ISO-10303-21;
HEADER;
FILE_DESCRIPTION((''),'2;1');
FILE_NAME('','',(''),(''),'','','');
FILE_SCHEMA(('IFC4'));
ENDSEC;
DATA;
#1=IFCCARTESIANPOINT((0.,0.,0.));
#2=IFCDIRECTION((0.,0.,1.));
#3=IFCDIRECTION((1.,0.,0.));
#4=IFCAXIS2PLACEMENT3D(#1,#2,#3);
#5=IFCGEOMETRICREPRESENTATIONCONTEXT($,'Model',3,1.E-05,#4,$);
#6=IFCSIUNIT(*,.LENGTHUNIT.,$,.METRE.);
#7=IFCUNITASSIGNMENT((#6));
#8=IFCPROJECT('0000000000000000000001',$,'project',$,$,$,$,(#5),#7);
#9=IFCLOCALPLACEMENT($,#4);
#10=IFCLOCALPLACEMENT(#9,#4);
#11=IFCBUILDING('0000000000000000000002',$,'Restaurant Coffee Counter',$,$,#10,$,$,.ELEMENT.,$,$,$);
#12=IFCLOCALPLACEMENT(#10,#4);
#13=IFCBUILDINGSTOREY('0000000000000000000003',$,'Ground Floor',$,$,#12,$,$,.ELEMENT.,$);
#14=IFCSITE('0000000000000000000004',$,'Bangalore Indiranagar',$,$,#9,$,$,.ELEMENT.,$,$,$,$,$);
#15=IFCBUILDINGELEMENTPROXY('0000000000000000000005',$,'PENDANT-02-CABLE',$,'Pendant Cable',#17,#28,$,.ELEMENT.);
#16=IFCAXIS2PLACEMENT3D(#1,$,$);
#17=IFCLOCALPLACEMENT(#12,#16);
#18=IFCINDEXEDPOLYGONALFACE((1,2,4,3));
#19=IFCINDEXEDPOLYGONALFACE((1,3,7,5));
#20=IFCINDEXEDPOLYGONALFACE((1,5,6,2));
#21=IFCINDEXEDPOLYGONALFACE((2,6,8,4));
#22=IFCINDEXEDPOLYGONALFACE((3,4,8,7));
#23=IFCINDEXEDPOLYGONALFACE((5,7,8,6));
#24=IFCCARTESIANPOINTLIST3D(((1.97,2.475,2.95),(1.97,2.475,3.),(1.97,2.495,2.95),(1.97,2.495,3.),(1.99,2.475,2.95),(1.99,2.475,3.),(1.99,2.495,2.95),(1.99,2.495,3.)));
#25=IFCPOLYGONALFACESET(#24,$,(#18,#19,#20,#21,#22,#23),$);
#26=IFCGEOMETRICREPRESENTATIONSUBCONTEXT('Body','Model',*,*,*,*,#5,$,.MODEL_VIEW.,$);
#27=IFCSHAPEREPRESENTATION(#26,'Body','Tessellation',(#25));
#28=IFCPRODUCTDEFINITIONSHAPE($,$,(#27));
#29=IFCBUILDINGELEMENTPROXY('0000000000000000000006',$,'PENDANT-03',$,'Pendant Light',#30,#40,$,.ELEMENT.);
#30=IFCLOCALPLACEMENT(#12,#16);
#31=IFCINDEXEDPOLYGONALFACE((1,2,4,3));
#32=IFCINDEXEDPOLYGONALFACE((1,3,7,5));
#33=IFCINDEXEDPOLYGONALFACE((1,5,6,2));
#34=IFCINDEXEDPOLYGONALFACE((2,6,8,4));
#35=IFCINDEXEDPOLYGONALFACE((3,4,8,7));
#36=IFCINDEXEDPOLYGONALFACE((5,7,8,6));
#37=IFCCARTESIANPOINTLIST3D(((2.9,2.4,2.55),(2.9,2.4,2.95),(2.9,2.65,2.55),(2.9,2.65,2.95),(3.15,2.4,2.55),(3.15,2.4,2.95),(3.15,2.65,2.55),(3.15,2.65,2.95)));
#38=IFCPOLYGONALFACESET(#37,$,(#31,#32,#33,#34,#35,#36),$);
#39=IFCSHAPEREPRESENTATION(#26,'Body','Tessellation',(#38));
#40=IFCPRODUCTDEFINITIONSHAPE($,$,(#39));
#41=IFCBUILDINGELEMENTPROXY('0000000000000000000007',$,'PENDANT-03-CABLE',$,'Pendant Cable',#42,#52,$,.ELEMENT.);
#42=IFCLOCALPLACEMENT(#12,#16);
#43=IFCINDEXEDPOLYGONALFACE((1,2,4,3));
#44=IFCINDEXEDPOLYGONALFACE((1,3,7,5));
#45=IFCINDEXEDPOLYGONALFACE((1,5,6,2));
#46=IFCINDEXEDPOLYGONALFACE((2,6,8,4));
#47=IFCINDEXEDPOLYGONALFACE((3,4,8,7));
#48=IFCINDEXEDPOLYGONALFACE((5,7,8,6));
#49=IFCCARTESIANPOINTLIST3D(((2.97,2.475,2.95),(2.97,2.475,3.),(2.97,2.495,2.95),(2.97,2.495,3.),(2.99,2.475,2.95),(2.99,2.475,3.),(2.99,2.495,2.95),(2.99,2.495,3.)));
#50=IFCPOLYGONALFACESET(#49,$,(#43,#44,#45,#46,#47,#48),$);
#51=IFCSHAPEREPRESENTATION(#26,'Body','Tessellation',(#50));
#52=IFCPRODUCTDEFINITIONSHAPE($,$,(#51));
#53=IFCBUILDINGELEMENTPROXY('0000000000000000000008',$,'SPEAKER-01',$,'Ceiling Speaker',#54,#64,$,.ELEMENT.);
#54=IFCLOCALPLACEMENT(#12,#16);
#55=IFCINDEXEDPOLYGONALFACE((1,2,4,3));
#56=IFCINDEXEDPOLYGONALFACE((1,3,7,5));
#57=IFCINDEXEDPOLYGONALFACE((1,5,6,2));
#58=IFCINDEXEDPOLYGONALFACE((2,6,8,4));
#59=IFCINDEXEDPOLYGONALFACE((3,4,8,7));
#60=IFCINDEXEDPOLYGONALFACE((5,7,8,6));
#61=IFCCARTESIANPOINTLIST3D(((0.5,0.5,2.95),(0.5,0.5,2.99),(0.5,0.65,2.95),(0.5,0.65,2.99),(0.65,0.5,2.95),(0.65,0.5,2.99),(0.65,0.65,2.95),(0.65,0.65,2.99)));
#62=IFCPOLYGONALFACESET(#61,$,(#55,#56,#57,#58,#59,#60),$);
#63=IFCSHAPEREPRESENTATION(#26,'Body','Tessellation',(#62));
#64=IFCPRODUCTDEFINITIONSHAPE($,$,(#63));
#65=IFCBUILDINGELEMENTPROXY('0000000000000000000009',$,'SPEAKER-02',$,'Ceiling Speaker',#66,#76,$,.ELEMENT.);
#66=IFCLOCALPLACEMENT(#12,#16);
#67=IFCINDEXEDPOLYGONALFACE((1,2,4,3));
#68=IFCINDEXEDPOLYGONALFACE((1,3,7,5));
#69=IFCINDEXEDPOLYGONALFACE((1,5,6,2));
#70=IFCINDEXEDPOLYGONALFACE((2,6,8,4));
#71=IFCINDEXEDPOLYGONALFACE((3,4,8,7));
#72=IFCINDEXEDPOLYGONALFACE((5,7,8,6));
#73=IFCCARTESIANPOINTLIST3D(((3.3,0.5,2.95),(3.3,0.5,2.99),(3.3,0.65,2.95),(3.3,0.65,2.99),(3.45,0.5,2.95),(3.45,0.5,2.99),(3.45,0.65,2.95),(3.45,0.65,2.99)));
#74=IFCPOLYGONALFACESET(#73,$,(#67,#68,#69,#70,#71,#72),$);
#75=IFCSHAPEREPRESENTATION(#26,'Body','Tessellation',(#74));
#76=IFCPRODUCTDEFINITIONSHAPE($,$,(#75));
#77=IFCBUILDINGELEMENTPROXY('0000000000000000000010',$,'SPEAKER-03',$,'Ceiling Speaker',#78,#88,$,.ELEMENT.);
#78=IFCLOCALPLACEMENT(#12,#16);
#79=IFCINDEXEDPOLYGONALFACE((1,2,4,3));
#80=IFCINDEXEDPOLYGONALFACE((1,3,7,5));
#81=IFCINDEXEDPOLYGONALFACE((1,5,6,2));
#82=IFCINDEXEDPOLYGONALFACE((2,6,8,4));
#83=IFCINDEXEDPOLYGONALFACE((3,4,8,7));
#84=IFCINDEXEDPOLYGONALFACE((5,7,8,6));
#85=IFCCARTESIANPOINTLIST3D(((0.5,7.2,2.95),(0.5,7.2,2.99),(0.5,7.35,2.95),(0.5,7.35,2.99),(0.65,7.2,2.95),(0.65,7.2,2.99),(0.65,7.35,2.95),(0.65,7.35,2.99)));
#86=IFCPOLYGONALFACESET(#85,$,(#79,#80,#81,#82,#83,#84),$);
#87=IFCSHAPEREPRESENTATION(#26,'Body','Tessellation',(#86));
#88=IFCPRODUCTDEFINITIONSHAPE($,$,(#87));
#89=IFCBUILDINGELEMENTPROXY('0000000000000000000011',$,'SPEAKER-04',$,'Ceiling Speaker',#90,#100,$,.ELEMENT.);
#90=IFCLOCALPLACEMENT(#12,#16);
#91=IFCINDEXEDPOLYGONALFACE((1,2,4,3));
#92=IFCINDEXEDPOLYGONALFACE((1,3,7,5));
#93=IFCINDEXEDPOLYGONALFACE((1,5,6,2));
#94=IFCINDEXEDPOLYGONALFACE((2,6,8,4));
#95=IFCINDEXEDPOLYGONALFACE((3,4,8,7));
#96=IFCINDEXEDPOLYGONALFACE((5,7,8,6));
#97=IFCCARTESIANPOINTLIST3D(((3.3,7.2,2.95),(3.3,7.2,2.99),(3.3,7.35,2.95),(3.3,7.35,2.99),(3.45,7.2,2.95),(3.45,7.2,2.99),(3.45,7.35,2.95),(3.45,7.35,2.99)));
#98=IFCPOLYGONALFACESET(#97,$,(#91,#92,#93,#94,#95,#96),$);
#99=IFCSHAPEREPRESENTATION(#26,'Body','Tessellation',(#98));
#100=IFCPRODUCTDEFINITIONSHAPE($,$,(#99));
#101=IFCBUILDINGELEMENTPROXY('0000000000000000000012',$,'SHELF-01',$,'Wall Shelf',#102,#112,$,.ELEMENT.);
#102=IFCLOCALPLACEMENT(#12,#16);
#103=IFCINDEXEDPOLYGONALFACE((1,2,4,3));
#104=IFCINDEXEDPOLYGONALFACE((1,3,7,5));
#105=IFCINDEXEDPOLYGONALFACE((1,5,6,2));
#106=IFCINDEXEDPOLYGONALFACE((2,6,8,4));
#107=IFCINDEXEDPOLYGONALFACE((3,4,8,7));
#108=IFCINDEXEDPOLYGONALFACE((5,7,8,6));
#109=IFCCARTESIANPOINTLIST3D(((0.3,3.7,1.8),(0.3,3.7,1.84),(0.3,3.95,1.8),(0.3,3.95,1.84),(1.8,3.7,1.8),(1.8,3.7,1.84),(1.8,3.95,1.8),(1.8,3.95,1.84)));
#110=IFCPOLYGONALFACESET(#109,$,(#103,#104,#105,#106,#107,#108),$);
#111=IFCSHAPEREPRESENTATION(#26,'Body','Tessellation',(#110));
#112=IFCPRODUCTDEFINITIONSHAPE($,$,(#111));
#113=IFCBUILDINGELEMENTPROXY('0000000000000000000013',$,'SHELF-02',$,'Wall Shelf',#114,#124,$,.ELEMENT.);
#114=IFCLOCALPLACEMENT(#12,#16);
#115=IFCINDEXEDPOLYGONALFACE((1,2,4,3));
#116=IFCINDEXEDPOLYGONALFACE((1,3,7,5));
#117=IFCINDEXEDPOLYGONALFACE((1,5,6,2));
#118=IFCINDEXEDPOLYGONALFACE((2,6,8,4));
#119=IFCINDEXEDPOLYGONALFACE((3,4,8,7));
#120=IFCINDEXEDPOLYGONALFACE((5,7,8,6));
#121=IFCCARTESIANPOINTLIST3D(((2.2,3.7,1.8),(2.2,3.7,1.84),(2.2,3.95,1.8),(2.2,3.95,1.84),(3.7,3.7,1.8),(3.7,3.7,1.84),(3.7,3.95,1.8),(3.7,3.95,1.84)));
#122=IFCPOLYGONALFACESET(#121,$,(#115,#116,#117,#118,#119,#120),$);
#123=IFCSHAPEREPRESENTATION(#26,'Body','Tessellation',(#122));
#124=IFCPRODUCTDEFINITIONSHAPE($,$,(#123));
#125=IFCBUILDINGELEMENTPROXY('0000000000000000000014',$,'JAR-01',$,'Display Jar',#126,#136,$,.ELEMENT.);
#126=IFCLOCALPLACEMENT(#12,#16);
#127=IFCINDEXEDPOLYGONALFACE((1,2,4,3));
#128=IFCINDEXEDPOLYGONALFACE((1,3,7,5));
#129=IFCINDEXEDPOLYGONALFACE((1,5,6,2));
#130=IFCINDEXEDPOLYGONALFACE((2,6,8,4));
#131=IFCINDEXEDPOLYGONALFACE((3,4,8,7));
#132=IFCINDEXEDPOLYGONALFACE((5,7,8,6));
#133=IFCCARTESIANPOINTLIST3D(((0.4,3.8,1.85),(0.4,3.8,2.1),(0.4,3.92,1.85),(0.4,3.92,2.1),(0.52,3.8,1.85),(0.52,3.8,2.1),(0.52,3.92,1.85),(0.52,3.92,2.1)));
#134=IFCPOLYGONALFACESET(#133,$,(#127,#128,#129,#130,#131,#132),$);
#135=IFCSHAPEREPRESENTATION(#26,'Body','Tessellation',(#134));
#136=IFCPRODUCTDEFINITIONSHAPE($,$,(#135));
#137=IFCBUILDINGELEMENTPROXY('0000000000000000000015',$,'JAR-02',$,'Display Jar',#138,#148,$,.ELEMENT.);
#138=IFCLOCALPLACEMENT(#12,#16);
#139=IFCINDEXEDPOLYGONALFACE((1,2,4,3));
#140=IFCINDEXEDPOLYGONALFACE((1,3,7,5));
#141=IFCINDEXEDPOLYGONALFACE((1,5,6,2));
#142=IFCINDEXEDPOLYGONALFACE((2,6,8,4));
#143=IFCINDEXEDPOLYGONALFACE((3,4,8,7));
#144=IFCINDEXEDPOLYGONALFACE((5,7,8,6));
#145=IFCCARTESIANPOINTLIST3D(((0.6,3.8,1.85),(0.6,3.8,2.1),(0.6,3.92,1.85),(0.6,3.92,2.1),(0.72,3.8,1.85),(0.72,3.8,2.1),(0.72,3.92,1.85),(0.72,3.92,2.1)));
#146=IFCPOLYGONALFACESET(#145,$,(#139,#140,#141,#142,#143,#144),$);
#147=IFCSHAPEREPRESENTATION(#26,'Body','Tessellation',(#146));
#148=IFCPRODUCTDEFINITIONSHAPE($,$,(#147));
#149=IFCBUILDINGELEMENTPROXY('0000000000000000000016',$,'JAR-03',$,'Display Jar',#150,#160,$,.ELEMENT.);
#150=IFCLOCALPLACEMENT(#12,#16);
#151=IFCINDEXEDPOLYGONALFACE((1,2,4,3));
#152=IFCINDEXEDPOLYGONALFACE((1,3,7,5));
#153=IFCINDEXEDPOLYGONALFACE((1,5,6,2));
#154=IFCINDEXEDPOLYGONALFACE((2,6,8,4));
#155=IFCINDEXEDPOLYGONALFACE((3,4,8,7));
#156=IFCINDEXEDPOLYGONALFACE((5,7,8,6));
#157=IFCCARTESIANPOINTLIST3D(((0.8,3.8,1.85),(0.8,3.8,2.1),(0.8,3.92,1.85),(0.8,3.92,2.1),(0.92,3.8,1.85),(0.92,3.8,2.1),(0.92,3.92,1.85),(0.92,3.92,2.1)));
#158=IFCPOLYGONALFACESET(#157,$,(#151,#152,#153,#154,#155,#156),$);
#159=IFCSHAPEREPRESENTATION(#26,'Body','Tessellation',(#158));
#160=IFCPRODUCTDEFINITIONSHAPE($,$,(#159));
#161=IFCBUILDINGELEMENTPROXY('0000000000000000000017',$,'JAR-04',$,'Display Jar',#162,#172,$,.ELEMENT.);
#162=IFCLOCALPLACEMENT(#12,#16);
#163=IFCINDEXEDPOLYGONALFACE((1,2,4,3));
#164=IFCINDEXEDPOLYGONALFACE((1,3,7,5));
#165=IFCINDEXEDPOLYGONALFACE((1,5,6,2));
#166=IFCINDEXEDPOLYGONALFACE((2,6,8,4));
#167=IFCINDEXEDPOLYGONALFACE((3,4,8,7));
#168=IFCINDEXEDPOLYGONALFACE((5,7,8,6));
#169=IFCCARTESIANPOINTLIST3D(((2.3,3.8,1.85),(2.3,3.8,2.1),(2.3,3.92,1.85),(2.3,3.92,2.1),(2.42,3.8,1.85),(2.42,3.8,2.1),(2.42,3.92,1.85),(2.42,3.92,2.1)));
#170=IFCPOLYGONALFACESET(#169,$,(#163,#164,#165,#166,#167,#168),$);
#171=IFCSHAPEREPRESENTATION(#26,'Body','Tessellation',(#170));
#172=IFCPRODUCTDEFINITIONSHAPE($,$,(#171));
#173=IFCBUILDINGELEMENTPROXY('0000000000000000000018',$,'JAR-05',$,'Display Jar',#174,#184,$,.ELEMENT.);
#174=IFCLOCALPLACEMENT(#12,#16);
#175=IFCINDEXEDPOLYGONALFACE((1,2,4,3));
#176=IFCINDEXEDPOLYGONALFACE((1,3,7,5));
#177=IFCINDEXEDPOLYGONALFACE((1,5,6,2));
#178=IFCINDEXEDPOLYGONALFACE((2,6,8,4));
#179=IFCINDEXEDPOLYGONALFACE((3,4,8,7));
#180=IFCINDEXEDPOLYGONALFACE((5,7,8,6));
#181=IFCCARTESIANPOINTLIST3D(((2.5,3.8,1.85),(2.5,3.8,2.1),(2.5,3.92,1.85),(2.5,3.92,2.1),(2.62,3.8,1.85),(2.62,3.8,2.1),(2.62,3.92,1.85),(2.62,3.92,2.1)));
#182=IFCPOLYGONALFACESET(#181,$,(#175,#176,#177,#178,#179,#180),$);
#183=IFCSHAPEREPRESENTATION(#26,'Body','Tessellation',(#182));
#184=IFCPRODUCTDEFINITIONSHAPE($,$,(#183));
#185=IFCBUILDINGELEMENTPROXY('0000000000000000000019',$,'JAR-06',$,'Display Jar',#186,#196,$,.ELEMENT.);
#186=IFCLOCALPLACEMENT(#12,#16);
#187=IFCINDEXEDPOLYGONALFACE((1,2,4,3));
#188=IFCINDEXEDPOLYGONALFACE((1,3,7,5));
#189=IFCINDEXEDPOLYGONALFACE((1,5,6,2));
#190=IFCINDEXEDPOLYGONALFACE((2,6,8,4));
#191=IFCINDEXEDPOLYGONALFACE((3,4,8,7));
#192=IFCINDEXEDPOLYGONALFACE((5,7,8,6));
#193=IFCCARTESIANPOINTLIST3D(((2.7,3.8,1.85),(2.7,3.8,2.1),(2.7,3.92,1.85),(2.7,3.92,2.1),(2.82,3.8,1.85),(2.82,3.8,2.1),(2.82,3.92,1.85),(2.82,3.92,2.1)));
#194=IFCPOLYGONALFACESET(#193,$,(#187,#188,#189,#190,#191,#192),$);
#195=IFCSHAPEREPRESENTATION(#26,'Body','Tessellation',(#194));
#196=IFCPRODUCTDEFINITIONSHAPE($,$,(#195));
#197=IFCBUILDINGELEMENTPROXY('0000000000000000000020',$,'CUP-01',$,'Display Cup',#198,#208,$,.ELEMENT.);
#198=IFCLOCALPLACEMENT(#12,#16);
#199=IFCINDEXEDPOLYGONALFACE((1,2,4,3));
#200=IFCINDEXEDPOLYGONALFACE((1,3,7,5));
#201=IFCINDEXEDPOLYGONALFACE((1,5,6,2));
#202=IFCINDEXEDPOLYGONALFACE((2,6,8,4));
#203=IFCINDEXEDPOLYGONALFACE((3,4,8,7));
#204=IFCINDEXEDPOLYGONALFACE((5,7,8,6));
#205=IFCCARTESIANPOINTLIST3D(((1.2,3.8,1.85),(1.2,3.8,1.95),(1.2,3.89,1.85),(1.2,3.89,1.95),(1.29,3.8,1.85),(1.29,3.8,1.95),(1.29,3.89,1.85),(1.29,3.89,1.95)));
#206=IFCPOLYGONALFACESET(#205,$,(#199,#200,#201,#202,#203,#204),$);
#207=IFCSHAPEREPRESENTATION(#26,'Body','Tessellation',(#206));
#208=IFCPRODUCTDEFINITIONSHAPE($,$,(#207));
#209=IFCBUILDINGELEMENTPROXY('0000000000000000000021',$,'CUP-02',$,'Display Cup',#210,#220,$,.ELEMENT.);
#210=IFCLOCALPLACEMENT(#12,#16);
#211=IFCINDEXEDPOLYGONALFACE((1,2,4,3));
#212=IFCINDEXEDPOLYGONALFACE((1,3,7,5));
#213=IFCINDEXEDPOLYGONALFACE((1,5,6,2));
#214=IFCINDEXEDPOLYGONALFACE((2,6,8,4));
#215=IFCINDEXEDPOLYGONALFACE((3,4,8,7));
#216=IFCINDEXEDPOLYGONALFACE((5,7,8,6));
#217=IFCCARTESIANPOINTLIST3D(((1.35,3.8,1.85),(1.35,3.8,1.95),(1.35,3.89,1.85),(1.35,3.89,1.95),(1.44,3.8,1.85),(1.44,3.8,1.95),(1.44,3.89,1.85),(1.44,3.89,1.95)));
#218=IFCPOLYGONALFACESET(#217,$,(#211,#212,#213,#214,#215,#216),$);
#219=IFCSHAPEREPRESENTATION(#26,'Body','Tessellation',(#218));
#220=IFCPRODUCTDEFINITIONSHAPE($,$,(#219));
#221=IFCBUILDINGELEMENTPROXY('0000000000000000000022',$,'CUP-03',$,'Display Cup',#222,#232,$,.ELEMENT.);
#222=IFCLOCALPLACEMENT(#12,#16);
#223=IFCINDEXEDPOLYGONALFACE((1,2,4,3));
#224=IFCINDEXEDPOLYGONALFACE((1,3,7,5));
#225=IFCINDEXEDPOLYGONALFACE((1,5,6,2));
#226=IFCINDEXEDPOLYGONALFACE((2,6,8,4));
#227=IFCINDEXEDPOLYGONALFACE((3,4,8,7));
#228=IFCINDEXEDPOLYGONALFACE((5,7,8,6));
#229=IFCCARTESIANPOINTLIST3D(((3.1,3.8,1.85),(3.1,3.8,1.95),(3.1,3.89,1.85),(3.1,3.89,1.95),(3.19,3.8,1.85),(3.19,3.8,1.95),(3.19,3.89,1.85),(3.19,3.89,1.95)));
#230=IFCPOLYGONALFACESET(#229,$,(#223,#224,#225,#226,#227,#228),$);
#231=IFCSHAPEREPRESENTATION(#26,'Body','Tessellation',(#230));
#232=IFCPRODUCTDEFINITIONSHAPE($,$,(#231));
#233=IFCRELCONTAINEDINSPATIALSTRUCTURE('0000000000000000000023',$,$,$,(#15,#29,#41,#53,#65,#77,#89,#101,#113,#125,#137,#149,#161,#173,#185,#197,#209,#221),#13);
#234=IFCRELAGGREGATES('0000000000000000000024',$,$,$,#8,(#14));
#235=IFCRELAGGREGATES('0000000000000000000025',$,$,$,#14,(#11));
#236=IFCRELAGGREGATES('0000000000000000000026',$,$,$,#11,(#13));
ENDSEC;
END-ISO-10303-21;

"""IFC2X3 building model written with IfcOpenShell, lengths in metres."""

from ifc_helpers import new_model, si_unit, frame, frame_2d, origin, origin_with_axes, place, context, subcontext, project, spatial, rectangle, extrude, element, save


model = new_model("IFC2X3")

# Units and contexts
model_context = context("Model", 3, precision=1e-05, world=origin_with_axes())
body_context = subcontext(model_context, "Body", "Model", "MODEL_VIEW")
ifc_project = project(units=[si_unit("LENGTHUNIT", "METRE")], contexts=[model_context])

# Site, building, storey
site_placement = place(None, origin_with_axes())
site = spatial("IfcSite", under=ifc_project, at=site_placement, Name="Bangalore Indiranagar", CompositionType="ELEMENT")
building_placement = place(site_placement, origin_with_axes())
building = spatial("IfcBuilding", under=site, at=building_placement, Name="Restaurant Coffee Counter", CompositionType="ELEMENT")
storey_placement = place(building_placement, origin_with_axes())
storey = spatial("IfcBuildingStorey", under=building, at=storey_placement, Name="Ground Floor", CompositionType="ELEMENT")

# Building element proxies
proxy_1_placement = place(storey_placement, frame((1.97, 2.475, 2.95), z_axis=(0.0, 0.0, 1.0), x_axis=(1.0, 0.0, 0.0)))
element("IfcBuildingElementProxy", 1, at=proxy_1_placement, inside=storey, Name="PENDANT-02-CABLE", ObjectType="Pendant Cable", CompositionType="ELEMENT", context=body_context, shape_type="SweptSolid", body=[
    extrude(rectangle(XDim=0.02, YDim=0.02, at=frame_2d((0.01, 0.01))), origin(), (0.0, 0.0, 1.0), 0.05),
])
proxy_2_placement = place(storey_placement, frame((2.9, 2.4, 2.55), z_axis=(0.0, 0.0, 1.0), x_axis=(1.0, 0.0, 0.0)))
element("IfcBuildingElementProxy", 2, at=proxy_2_placement, inside=storey, Name="PENDANT-03", ObjectType="Pendant Light", CompositionType="ELEMENT", context=body_context, shape_type="SweptSolid", body=[
    extrude(rectangle(XDim=0.25, YDim=0.25, at=frame_2d((0.125, 0.125))), origin(), (0.0, 0.0, 1.0), 0.4),
])
proxy_3_placement = place(storey_placement, frame((2.97, 2.475, 2.95), z_axis=(0.0, 0.0, 1.0), x_axis=(1.0, 0.0, 0.0)))
element("IfcBuildingElementProxy", 3, at=proxy_3_placement, inside=storey, Name="PENDANT-03-CABLE", ObjectType="Pendant Cable", CompositionType="ELEMENT", context=body_context, shape_type="SweptSolid", body=[
    extrude(rectangle(XDim=0.02, YDim=0.02, at=frame_2d((0.01, 0.01))), origin(), (0.0, 0.0, 1.0), 0.05),
])
for number, where, z_axis, x_axis, name in (
    (4, (0.5, 0.5, 2.95), (0.0, 0.0, 1.0), (1.0, 0.0, 0.0), "SPEAKER-01"),
    (5, (3.3, 0.5, 2.95), (0.0, 0.0, 1.0), (1.0, 0.0, 0.0), "SPEAKER-02"),
    (6, (0.5, 7.2, 2.95), (0.0, 0.0, 1.0), (1.0, 0.0, 0.0), "SPEAKER-03"),
    (7, (3.3, 7.2, 2.95), (0.0, 0.0, 1.0), (1.0, 0.0, 0.0), "SPEAKER-04"),
):
    element("IfcBuildingElementProxy", number, at=place(storey_placement, frame(where, z_axis=z_axis, x_axis=x_axis)), inside=storey, Name=name, ObjectType="Ceiling Speaker", CompositionType="ELEMENT", context=body_context, shape_type="SweptSolid", body=[
        extrude(rectangle(XDim=0.15, YDim=0.15, at=frame_2d((0.075, 0.075))), origin(), (0.0, 0.0, 1.0), 0.04),
    ])
for number, where, z_axis, x_axis, name in (
    (8, (0.3, 3.7, 1.8), (0.0, 0.0, 1.0), (1.0, 0.0, 0.0), "SHELF-01"),
    (9, (2.2, 3.7, 1.8), (0.0, 0.0, 1.0), (1.0, 0.0, 0.0), "SHELF-02"),
):
    element("IfcBuildingElementProxy", number, at=place(storey_placement, frame(where, z_axis=z_axis, x_axis=x_axis)), inside=storey, Name=name, ObjectType="Wall Shelf", CompositionType="ELEMENT", context=body_context, shape_type="SweptSolid", body=[
        extrude(rectangle(XDim=1.5, YDim=0.25, at=frame_2d((0.75, 0.125))), origin(), (0.0, 0.0, 1.0), 0.04),
    ])
for number, where, z_axis, x_axis, name in (
    (10, (0.4, 3.8, 1.85), (0.0, 0.0, 1.0), (1.0, 0.0, 0.0), "JAR-01"),
    (11, (0.6, 3.8, 1.85), (0.0, 0.0, 1.0), (1.0, 0.0, 0.0), "JAR-02"),
    (12, (0.8, 3.8, 1.85), (0.0, 0.0, 1.0), (1.0, 0.0, 0.0), "JAR-03"),
    (13, (2.3, 3.8, 1.85), (0.0, 0.0, 1.0), (1.0, 0.0, 0.0), "JAR-04"),
    (14, (2.5, 3.8, 1.85), (0.0, 0.0, 1.0), (1.0, 0.0, 0.0), "JAR-05"),
    (15, (2.7, 3.8, 1.85), (0.0, 0.0, 1.0), (1.0, 0.0, 0.0), "JAR-06"),
):
    element("IfcBuildingElementProxy", number, at=place(storey_placement, frame(where, z_axis=z_axis, x_axis=x_axis)), inside=storey, Name=name, ObjectType="Display Jar", CompositionType="ELEMENT", context=body_context, shape_type="SweptSolid", body=[
        extrude(rectangle(XDim=0.12, YDim=0.12, at=frame_2d((0.06, 0.06))), origin(), (0.0, 0.0, 1.0), 0.25),
    ])
for number, where, z_axis, x_axis, name in (
    (16, (1.2, 3.8, 1.85), (0.0, 0.0, 1.0), (1.0, 0.0, 0.0), "CUP-01"),
    (17, (1.35, 3.8, 1.85), (0.0, 0.0, 1.0), (1.0, 0.0, 0.0), "CUP-02"),
    (18, (3.1, 3.8, 1.85), (0.0, 0.0, 1.0), (1.0, 0.0, 0.0), "CUP-03"),
):
    element("IfcBuildingElementProxy", number, at=place(storey_placement, frame(where, z_axis=z_axis, x_axis=x_axis)), inside=storey, Name=name, ObjectType="Display Cup", CompositionType="ELEMENT", context=body_context, shape_type="SweptSolid", body=[
        extrude(rectangle(XDim=0.09, YDim=0.09, at=frame_2d((0.045, 0.045))), origin(), (0.0, 0.0, 1.0), 0.1),
    ])

save(model, "model.ifc")
